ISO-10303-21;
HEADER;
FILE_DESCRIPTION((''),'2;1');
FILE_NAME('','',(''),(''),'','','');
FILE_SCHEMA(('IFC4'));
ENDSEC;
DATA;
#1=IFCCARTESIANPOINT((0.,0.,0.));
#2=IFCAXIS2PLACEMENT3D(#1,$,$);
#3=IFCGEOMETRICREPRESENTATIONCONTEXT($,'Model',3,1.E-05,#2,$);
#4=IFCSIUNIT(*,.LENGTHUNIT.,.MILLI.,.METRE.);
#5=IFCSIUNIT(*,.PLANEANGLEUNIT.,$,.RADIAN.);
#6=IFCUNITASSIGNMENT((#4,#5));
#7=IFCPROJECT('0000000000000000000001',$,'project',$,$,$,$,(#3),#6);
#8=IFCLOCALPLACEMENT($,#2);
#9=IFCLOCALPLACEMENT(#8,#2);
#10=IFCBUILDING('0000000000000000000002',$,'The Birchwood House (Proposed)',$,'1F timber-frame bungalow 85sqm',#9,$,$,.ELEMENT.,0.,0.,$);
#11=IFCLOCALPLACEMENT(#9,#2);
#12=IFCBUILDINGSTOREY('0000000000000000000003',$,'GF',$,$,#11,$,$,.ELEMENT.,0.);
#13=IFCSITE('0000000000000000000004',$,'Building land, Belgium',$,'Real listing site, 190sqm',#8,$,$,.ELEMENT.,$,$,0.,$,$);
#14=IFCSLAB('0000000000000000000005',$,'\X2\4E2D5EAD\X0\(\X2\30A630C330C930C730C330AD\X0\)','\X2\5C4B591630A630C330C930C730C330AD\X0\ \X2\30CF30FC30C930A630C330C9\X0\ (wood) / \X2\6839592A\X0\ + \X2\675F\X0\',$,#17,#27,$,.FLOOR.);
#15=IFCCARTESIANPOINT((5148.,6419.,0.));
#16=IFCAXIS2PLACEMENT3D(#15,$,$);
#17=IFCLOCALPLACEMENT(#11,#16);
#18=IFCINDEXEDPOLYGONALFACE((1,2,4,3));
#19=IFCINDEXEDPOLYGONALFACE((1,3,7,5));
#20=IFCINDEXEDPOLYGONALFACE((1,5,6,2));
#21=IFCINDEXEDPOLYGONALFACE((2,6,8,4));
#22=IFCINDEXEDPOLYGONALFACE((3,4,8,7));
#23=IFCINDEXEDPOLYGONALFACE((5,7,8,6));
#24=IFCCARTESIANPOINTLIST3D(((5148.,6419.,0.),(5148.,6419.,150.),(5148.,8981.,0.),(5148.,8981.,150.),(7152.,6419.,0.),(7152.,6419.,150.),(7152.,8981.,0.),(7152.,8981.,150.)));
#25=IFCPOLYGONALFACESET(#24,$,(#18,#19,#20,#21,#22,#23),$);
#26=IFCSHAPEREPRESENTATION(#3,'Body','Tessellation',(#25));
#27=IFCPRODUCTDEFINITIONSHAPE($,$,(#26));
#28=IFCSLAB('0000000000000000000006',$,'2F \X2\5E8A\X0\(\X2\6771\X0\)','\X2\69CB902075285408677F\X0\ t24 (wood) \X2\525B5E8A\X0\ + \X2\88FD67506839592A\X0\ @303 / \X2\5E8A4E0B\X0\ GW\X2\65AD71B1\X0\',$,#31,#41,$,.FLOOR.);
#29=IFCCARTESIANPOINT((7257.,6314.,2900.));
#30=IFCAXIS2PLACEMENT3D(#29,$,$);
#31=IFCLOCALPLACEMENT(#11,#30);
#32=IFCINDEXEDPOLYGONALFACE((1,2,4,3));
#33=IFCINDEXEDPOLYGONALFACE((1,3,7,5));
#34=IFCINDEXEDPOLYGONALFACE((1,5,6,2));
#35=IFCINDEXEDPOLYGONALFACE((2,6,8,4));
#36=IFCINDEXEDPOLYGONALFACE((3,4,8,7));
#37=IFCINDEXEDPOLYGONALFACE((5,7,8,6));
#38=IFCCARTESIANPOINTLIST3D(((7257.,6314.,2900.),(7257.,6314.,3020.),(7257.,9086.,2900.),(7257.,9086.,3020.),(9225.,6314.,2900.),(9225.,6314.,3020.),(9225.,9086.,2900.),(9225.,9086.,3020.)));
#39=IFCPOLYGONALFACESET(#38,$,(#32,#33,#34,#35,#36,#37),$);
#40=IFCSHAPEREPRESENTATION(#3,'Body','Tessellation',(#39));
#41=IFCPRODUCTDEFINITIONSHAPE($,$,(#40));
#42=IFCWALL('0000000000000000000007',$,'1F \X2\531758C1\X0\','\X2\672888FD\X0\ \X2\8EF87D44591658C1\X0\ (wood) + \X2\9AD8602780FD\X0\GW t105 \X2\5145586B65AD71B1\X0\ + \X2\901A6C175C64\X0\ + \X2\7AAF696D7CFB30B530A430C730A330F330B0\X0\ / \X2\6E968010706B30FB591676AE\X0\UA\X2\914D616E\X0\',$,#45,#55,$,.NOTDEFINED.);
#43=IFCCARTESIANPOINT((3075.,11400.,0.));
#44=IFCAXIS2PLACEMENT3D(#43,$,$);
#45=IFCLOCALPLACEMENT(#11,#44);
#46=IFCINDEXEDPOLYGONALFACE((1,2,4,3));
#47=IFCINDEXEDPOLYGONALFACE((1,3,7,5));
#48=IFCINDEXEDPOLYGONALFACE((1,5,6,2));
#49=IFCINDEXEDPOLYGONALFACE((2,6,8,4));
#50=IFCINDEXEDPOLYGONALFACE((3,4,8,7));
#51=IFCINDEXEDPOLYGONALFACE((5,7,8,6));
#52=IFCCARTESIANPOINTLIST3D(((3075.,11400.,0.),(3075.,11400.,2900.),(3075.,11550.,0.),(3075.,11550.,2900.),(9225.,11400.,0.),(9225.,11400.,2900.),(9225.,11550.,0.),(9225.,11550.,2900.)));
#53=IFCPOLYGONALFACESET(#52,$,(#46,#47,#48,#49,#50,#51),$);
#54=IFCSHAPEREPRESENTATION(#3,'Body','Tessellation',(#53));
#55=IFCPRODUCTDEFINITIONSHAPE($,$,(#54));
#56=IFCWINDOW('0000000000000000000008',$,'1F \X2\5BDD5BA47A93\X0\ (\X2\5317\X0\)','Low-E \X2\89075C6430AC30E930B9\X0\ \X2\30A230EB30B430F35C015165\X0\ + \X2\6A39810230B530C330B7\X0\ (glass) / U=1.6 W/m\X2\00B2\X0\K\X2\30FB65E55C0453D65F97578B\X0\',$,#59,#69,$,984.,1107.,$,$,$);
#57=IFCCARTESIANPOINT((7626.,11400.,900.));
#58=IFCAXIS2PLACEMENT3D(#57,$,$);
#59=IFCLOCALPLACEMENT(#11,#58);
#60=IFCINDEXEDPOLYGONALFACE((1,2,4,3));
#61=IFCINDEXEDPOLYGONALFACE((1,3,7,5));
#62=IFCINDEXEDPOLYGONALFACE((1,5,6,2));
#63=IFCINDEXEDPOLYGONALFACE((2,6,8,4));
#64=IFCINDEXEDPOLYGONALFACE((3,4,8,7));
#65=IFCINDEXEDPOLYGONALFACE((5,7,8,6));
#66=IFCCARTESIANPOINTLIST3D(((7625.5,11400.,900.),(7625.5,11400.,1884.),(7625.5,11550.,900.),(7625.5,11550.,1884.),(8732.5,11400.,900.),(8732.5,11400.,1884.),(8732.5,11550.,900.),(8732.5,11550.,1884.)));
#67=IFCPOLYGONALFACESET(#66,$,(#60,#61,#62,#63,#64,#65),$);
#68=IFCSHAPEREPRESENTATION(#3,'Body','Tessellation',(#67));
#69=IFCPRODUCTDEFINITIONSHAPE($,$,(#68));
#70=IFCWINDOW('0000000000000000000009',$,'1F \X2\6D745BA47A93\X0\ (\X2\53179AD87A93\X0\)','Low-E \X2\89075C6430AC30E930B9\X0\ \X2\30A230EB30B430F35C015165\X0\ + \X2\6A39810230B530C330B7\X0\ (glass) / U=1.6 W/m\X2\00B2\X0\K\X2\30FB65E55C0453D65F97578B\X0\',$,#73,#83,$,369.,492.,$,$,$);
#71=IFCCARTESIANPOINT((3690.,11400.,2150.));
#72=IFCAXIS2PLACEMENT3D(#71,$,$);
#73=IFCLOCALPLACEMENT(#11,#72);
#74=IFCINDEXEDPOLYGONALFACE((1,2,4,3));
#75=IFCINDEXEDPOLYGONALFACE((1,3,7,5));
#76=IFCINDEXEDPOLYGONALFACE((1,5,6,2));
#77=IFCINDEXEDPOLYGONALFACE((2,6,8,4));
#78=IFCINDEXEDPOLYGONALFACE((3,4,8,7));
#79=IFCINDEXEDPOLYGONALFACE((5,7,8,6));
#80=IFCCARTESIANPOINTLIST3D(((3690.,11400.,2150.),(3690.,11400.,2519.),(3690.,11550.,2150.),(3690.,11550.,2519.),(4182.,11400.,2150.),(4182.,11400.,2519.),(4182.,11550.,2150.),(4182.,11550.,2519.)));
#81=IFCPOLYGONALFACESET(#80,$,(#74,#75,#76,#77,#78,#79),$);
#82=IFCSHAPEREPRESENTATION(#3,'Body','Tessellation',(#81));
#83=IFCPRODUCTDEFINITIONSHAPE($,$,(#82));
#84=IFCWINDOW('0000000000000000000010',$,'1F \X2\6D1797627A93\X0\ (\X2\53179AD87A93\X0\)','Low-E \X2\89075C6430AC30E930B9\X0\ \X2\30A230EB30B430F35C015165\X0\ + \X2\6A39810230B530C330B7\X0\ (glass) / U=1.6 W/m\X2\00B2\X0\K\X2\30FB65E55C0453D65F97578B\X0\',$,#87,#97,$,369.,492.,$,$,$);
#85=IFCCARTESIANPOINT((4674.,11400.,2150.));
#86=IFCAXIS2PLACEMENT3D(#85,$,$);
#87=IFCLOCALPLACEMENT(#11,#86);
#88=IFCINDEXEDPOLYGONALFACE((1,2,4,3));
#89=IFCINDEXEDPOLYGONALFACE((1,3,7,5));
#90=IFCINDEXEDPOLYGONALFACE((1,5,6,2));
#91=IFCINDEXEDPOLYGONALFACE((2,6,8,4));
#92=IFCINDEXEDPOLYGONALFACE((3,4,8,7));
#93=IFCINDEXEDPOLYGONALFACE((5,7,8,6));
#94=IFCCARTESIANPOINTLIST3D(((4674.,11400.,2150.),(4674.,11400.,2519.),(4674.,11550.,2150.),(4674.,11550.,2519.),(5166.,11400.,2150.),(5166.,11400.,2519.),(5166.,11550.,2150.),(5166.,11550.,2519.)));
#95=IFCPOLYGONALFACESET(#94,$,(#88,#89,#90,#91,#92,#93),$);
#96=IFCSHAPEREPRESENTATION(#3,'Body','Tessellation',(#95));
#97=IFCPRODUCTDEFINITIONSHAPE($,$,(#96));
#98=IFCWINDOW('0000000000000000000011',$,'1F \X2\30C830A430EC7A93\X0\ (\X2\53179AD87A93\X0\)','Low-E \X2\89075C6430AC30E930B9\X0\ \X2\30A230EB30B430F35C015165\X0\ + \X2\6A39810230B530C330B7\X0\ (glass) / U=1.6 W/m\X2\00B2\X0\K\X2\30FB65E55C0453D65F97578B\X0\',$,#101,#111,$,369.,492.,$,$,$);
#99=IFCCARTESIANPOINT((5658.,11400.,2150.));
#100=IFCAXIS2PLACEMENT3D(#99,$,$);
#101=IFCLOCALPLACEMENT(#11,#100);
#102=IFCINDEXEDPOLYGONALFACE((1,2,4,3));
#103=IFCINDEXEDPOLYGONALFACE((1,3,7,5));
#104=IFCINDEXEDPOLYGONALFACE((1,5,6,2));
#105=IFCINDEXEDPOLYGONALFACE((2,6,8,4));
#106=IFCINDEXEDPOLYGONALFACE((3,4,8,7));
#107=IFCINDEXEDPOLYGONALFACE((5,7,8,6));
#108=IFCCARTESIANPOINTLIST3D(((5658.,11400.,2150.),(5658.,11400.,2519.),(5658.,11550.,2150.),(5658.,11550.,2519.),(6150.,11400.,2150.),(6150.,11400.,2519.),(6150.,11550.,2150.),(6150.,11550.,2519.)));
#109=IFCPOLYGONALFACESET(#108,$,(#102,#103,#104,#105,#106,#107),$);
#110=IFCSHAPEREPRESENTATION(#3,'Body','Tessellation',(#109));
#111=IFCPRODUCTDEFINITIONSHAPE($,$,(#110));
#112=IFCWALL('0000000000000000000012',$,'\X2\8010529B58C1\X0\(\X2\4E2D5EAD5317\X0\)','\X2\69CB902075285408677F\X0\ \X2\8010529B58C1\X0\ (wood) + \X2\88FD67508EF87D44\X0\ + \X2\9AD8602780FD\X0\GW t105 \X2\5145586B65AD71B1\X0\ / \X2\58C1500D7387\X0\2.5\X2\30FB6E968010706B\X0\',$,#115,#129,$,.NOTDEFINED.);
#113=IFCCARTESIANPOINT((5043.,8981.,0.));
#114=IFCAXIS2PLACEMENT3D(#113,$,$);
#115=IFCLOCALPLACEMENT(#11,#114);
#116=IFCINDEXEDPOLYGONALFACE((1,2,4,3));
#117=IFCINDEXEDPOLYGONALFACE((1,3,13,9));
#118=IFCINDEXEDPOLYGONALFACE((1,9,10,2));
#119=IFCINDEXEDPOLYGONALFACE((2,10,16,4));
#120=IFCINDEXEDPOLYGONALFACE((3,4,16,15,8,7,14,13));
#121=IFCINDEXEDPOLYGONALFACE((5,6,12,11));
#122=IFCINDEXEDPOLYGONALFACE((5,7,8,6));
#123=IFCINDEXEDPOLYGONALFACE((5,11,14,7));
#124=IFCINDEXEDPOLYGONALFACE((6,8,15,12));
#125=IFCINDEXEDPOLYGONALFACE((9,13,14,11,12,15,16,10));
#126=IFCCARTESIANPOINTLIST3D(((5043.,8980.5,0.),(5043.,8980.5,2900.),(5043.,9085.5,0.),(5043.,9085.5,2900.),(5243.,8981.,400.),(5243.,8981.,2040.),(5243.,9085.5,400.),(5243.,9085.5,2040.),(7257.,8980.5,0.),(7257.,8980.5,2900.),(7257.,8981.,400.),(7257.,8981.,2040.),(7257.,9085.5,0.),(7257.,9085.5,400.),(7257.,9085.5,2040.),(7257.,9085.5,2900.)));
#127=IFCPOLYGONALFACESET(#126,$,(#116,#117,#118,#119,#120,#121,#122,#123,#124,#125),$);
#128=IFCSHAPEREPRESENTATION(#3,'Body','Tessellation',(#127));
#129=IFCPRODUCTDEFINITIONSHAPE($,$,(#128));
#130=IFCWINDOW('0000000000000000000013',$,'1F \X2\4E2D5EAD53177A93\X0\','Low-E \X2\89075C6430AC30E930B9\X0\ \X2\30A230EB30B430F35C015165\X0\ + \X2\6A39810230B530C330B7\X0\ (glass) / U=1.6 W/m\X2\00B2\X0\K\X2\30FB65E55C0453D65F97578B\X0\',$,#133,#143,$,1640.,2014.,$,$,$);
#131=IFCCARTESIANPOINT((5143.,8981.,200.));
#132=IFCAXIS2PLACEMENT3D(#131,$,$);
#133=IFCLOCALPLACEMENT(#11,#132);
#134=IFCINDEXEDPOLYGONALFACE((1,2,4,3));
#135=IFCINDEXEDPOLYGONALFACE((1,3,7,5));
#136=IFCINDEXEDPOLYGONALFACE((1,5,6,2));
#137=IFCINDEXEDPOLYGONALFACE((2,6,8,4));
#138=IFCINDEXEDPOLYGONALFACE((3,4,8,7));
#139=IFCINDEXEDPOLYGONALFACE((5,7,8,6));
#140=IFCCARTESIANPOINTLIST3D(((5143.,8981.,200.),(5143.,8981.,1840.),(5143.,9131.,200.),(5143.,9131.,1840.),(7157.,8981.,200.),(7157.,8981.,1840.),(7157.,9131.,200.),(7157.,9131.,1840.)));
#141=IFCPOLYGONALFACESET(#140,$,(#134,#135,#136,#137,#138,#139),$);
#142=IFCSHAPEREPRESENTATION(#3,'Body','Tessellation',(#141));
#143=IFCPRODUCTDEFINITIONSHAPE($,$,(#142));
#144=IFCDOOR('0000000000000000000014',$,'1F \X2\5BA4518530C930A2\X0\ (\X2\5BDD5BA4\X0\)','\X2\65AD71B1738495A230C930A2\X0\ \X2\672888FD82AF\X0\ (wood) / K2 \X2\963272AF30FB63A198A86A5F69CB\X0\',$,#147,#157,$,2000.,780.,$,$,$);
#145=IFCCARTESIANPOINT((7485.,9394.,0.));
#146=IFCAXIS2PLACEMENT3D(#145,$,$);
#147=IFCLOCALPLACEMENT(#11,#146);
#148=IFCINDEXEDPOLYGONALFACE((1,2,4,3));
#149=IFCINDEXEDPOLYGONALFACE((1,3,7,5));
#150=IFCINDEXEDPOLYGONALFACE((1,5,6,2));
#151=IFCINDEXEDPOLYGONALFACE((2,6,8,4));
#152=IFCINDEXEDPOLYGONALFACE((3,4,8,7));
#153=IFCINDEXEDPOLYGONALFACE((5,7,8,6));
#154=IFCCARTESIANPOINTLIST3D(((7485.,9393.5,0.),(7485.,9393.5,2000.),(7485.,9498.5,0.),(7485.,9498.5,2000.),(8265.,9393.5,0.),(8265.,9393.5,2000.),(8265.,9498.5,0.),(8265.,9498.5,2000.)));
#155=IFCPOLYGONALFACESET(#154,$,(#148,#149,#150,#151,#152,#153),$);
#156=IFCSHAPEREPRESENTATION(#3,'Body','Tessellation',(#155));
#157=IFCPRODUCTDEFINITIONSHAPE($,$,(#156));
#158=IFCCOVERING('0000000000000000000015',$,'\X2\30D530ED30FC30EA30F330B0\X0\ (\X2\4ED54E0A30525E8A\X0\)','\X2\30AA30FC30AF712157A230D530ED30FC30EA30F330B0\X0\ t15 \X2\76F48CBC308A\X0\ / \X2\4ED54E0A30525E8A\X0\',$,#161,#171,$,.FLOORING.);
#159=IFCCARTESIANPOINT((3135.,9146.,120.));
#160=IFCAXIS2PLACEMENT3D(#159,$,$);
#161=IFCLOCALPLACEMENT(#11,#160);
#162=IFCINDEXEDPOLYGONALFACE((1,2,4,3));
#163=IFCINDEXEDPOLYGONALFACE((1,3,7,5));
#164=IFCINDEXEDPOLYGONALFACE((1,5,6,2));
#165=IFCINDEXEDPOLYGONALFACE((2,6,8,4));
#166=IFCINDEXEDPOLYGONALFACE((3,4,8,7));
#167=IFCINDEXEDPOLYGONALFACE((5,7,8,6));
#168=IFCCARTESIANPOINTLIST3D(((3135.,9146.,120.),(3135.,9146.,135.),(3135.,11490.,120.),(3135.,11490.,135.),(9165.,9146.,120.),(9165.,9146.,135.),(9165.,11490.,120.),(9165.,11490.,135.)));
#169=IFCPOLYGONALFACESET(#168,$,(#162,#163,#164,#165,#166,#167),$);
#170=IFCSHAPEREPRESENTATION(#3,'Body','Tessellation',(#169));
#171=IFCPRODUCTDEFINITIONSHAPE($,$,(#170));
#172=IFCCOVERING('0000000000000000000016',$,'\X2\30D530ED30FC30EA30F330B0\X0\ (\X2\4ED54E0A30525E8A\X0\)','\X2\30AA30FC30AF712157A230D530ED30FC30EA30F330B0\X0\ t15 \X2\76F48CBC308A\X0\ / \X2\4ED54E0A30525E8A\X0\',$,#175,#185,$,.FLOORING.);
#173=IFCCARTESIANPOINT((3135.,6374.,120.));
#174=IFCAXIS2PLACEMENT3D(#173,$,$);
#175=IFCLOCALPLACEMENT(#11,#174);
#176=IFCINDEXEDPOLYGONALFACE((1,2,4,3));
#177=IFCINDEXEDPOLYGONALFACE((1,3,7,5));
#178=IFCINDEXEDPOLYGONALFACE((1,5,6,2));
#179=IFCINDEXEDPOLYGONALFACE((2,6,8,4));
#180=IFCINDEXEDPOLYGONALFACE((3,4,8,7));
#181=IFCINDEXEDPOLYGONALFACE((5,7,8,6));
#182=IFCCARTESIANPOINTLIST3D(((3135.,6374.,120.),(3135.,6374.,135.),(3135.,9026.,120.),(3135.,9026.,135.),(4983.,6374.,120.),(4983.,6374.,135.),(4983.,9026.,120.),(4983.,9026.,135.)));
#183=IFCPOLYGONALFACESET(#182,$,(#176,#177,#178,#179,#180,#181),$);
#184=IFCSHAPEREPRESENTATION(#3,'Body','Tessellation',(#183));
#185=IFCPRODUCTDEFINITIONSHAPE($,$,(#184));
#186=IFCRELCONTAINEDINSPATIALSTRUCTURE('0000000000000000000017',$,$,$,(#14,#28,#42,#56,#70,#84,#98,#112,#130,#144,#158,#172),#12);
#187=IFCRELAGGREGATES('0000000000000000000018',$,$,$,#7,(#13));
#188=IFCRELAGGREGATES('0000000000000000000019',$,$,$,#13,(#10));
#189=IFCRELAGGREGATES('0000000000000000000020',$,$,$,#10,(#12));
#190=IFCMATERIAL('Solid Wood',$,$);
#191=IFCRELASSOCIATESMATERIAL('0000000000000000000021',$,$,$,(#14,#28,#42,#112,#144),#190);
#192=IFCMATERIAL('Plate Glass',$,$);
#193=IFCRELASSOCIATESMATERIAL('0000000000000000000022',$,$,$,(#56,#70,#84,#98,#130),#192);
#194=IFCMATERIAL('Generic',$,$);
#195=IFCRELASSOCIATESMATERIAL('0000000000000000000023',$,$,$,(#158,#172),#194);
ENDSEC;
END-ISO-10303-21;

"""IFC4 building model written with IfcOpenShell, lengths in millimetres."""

from ifc_helpers import new_model, si_unit, frame, frame_2d, origin, place, context, project, spatial, rectangle, extrude, material, element, fill, save


model = new_model("IFC4")

# Units and contexts
model_context = context("Model", 3, precision=1e-05, world=origin())
ifc_project = project(units=[si_unit("LENGTHUNIT", "METRE", prefix="MILLI"), si_unit("PLANEANGLEUNIT", "RADIAN")], contexts=[model_context])

# Site, building, storey
site_placement = place(None, origin())
site = spatial("IfcSite", under=ifc_project, at=site_placement, Name="Building land, Belgium", ObjectType="Real listing site, 190sqm", CompositionType="ELEMENT", RefElevation=0.0)
building_placement = place(site_placement, origin())
building = spatial("IfcBuilding", under=site, at=building_placement, Name="The Birchwood House (Proposed)", ObjectType="1F timber-frame bungalow 85sqm", CompositionType="ELEMENT", ElevationOfRefHeight=0.0, ElevationOfTerrain=0.0)
storey_placement = place(building_placement, origin())
storey = spatial("IfcBuildingStorey", under=building, at=storey_placement, Name="GF", CompositionType="ELEMENT", Elevation=0.0)

# Slabs
ifc_material_1 = material(Name="Solid Wood")
slab_1_placement = place(storey_placement, frame((5148.0, 6419.0, 0.0)))
element("IfcSlab", 1, at=slab_1_placement, inside=storey, material=ifc_material_1, Name="中庭(ウッドデッキ)", Description="屋外ウッドデッキ ハードウッド (wood) / 根太 + 束", PredefinedType="FLOOR", context=model_context, shape_type="SweptSolid", body=[
    extrude(rectangle(XDim=2004.0, YDim=2562.0, at=frame_2d((1002.0, 1281.0))), frame((5148.0, 6419.0, 0.0)), (0.0, 0.0, 1.0), 150.0),
])
slab_2_placement = place(storey_placement, frame((7257.0, 6314.0, 2900.0)))
element("IfcSlab", 2, at=slab_2_placement, inside=storey, material=ifc_material_1, Name="2F 床(東)", Description="構造用合板 t24 (wood) 剛床 + 製材根太 @303 / 床下 GW断熱", PredefinedType="FLOOR", context=model_context, shape_type="SweptSolid", body=[
    extrude(rectangle(XDim=1968.0, YDim=2772.0, at=frame_2d((984.0, 1386.0))), frame((7257.0, 6314.0, 2900.0)), (0.0, 0.0, 1.0), 120.0),
])

# Wall, openings, windows
wall_1_placement = place(storey_placement, frame((3075.0, 11400.0, 0.0)))
wall_1 = element("IfcWall", 3, at=wall_1_placement, inside=storey, material=ifc_material_1, Name="1F 北壁", Description="木製 軸組外壁 (wood) + 高性能GW t105 充填断熱 + 通気層 + 窯業系サイディング / 準耐火・外皮UA配慮", PredefinedType="NOTDEFINED", context=model_context, shape_type="SweptSolid", body=[
    extrude(rectangle(XDim=6150.0, YDim=150.0, at=frame_2d((3075.0, 75.0))), frame((3075.0, 11400.0, 0.0)), (0.0, 0.0, 1.0), 2900.0),
])
opening_1_placement = place(storey_placement, frame((7626.0, 11400.0, 900.0)))
opening_1 = element("IfcOpeningElement", 4, at=opening_1_placement, cuts=wall_1, PredefinedType="NOTDEFINED", context=model_context, shape_type="SweptSolid", body=[
    extrude(rectangle(XDim=1107.0, YDim=150.0, at=frame_2d((553.0, 75.0))), frame((7626.0, 11400.0, 900.0)), (0.0, 0.0, 1.0), 984.0),
])
opening_2_placement = place(storey_placement, frame((3690.0, 11400.0, 2150.0)))
opening_2 = element("IfcOpeningElement", 5, at=opening_2_placement, cuts=wall_1, PredefinedType="NOTDEFINED", context=model_context, shape_type="SweptSolid", body=[
    extrude(rectangle(XDim=492.0, YDim=150.0, at=frame_2d((246.0, 75.0))), frame((3690.0, 11400.0, 2150.0)), (0.0, 0.0, 1.0), 369.0),
])
opening_3_placement = place(storey_placement, frame((4674.0, 11400.0, 2150.0)))
opening_3 = element("IfcOpeningElement", 6, at=opening_3_placement, cuts=wall_1, PredefinedType="NOTDEFINED", context=model_context, shape_type="SweptSolid", body=[
    extrude(rectangle(XDim=492.0, YDim=150.0, at=frame_2d((246.0, 75.0))), frame((4674.0, 11400.0, 2150.0)), (0.0, 0.0, 1.0), 369.0),
])
opening_4_placement = place(storey_placement, frame((5658.0, 11400.0, 2150.0)))
opening_4 = element("IfcOpeningElement", 7, at=opening_4_placement, cuts=wall_1, PredefinedType="NOTDEFINED", context=model_context, shape_type="SweptSolid", body=[
    extrude(rectangle(XDim=492.0, YDim=150.0, at=frame_2d((246.0, 75.0))), frame((5658.0, 11400.0, 2150.0)), (0.0, 0.0, 1.0), 369.0),
])
ifc_material_2 = material(Name="Plate Glass")
window_1_placement = place(storey_placement, frame((7626.0, 11400.0, 900.0)))
window_1 = element("IfcWindow", 8, at=window_1_placement, inside=storey, material=ifc_material_2, Name="1F 寝室窓 (北)", Description="Low-E 複層ガラス アルゴン封入 + 樹脂サッシ (glass) / U=1.6 W/m²K・日射取得型", OverallHeight=984.0, OverallWidth=1107.0, context=model_context, shape_type="SweptSolid", body=[
    extrude(rectangle(XDim=1107.0, YDim=150.0, at=frame_2d((553.0, 75.0))), frame((7626.0, 11400.0, 900.0)), (0.0, 0.0, 1.0), 984.0),
])
fill(opening_1, window_1)
window_2_placement = place(storey_placement, frame((3690.0, 11400.0, 2150.0)))
window_2 = element("IfcWindow", 9, at=window_2_placement, inside=storey, material=ifc_material_2, Name="1F 浴室窓 (北高窓)", Description="Low-E 複層ガラス アルゴン封入 + 樹脂サッシ (glass) / U=1.6 W/m²K・日射取得型", OverallHeight=369.0, OverallWidth=492.0, context=model_context, shape_type="SweptSolid", body=[
    extrude(rectangle(XDim=492.0, YDim=150.0, at=frame_2d((246.0, 75.0))), frame((3690.0, 11400.0, 2150.0)), (0.0, 0.0, 1.0), 369.0),
])
fill(opening_2, window_2)
window_3_placement = place(storey_placement, frame((4674.0, 11400.0, 2150.0)))
window_3 = element("IfcWindow", 10, at=window_3_placement, inside=storey, material=ifc_material_2, Name="1F 洗面窓 (北高窓)", Description="Low-E 複層ガラス アルゴン封入 + 樹脂サッシ (glass) / U=1.6 W/m²K・日射取得型", OverallHeight=369.0, OverallWidth=492.0, context=model_context, shape_type="SweptSolid", body=[
    extrude(rectangle(XDim=492.0, YDim=150.0, at=frame_2d((246.0, 75.0))), frame((4674.0, 11400.0, 2150.0)), (0.0, 0.0, 1.0), 369.0),
])
fill(opening_3, window_3)
window_4_placement = place(storey_placement, frame((5658.0, 11400.0, 2150.0)))
window_4 = element("IfcWindow", 11, at=window_4_placement, inside=storey, material=ifc_material_2, Name="1F トイレ窓 (北高窓)", Description="Low-E 複層ガラス アルゴン封入 + 樹脂サッシ (glass) / U=1.6 W/m²K・日射取得型", OverallHeight=369.0, OverallWidth=492.0, context=model_context, shape_type="SweptSolid", body=[
    extrude(rectangle(XDim=492.0, YDim=150.0, at=frame_2d((246.0, 75.0))), frame((5658.0, 11400.0, 2150.0)), (0.0, 0.0, 1.0), 369.0),
])
fill(opening_4, window_4)

# Wall, opening, window
wall_2_placement = place(storey_placement, frame((5043.0, 8981.0, 0.0)))
wall_2 = element("IfcWall", 12, at=wall_2_placement, inside=storey, material=ifc_material_1, Name="耐力壁(中庭北)", Description="構造用合板 耐力壁 (wood) + 製材軸組 + 高性能GW t105 充填断熱 / 壁倍率2.5・準耐火", PredefinedType="NOTDEFINED", context=model_context, shape_type="SweptSolid", body=[
    extrude(rectangle(XDim=2214.0, YDim=105.0, at=frame_2d((1107.0, 52.0))), frame((5043.0, 8981.0, 0.0)), (0.0, 0.0, 1.0), 2900.0),
])
opening_5_placement = place(storey_placement, frame((5143.0, 8981.0, 200.0)))
opening_5 = element("IfcOpeningElement", 13, at=opening_5_placement, cuts=wall_2, PredefinedType="NOTDEFINED", context=model_context, shape_type="SweptSolid", body=[
    extrude(rectangle(XDim=2014.0, YDim=150.0, at=frame_2d((1007.0, 75.0))), frame((5143.0, 8981.0, 200.0)), (0.0, 0.0, 1.0), 1640.0),
])
window_5_placement = place(storey_placement, frame((5143.0, 8981.0, 200.0)))
window_5 = element("IfcWindow", 14, at=window_5_placement, inside=storey, material=ifc_material_2, Name="1F 中庭北窓", Description="Low-E 複層ガラス アルゴン封入 + 樹脂サッシ (glass) / U=1.6 W/m²K・日射取得型", OverallHeight=1640.0, OverallWidth=2014.0, context=model_context, shape_type="SweptSolid", body=[
    extrude(rectangle(XDim=2014.0, YDim=150.0, at=frame_2d((1007.0, 75.0))), frame((5143.0, 8981.0, 200.0)), (0.0, 0.0, 1.0), 1640.0),
])
fill(opening_5, window_5)

# Door
door_1_placement = place(storey_placement, frame((7485.0, 9394.0, 0.0)))
element("IfcDoor", 15, at=door_1_placement, inside=storey, material=ifc_material_1, Name="1F 室内ドア (寝室)", Description="断熱玄関ドア 木製芯 (wood) / K2 防犯・採風機構", OverallHeight=2000.0, OverallWidth=780.0, context=model_context, shape_type="SweptSolid", body=[
    extrude(rectangle(XDim=780.0, YDim=105.0, at=frame_2d((390.0, 52.0))), frame((7485.0, 9394.0, 0.0)), (0.0, 0.0, 1.0), 2000.0),
])

# Coverings
ifc_material_3 = material(Name="Generic")
covering_1_placement = place(storey_placement, frame((3135.0, 9146.0, 120.0)))
element("IfcCovering", 16, at=covering_1_placement, inside=storey, material=ifc_material_3, Name="フローリング (仕上げ床)", Description="オーク無垢フローリング t15 直貼り / 仕上げ床", PredefinedType="FLOORING", context=model_context, shape_type="SweptSolid", body=[
    extrude(rectangle(XDim=6030.0, YDim=2344.0, at=frame_2d((3015.0, 1172.0))), frame((3135.0, 9146.0, 120.0)), (0.0, 0.0, 1.0), 15.0),
])
covering_2_placement = place(storey_placement, frame((3135.0, 6374.0, 120.0)))
element("IfcCovering", 17, at=covering_2_placement, inside=storey, material=ifc_material_3, Name="フローリング (仕上げ床)", Description="オーク無垢フローリング t15 直貼り / 仕上げ床", PredefinedType="FLOORING", context=model_context, shape_type="SweptSolid", body=[
    extrude(rectangle(XDim=1848.0, YDim=2652.0, at=frame_2d((924.0, 1326.0))), frame((3135.0, 6374.0, 120.0)), (0.0, 0.0, 1.0), 15.0),
])

save(model, "model.ifc")
